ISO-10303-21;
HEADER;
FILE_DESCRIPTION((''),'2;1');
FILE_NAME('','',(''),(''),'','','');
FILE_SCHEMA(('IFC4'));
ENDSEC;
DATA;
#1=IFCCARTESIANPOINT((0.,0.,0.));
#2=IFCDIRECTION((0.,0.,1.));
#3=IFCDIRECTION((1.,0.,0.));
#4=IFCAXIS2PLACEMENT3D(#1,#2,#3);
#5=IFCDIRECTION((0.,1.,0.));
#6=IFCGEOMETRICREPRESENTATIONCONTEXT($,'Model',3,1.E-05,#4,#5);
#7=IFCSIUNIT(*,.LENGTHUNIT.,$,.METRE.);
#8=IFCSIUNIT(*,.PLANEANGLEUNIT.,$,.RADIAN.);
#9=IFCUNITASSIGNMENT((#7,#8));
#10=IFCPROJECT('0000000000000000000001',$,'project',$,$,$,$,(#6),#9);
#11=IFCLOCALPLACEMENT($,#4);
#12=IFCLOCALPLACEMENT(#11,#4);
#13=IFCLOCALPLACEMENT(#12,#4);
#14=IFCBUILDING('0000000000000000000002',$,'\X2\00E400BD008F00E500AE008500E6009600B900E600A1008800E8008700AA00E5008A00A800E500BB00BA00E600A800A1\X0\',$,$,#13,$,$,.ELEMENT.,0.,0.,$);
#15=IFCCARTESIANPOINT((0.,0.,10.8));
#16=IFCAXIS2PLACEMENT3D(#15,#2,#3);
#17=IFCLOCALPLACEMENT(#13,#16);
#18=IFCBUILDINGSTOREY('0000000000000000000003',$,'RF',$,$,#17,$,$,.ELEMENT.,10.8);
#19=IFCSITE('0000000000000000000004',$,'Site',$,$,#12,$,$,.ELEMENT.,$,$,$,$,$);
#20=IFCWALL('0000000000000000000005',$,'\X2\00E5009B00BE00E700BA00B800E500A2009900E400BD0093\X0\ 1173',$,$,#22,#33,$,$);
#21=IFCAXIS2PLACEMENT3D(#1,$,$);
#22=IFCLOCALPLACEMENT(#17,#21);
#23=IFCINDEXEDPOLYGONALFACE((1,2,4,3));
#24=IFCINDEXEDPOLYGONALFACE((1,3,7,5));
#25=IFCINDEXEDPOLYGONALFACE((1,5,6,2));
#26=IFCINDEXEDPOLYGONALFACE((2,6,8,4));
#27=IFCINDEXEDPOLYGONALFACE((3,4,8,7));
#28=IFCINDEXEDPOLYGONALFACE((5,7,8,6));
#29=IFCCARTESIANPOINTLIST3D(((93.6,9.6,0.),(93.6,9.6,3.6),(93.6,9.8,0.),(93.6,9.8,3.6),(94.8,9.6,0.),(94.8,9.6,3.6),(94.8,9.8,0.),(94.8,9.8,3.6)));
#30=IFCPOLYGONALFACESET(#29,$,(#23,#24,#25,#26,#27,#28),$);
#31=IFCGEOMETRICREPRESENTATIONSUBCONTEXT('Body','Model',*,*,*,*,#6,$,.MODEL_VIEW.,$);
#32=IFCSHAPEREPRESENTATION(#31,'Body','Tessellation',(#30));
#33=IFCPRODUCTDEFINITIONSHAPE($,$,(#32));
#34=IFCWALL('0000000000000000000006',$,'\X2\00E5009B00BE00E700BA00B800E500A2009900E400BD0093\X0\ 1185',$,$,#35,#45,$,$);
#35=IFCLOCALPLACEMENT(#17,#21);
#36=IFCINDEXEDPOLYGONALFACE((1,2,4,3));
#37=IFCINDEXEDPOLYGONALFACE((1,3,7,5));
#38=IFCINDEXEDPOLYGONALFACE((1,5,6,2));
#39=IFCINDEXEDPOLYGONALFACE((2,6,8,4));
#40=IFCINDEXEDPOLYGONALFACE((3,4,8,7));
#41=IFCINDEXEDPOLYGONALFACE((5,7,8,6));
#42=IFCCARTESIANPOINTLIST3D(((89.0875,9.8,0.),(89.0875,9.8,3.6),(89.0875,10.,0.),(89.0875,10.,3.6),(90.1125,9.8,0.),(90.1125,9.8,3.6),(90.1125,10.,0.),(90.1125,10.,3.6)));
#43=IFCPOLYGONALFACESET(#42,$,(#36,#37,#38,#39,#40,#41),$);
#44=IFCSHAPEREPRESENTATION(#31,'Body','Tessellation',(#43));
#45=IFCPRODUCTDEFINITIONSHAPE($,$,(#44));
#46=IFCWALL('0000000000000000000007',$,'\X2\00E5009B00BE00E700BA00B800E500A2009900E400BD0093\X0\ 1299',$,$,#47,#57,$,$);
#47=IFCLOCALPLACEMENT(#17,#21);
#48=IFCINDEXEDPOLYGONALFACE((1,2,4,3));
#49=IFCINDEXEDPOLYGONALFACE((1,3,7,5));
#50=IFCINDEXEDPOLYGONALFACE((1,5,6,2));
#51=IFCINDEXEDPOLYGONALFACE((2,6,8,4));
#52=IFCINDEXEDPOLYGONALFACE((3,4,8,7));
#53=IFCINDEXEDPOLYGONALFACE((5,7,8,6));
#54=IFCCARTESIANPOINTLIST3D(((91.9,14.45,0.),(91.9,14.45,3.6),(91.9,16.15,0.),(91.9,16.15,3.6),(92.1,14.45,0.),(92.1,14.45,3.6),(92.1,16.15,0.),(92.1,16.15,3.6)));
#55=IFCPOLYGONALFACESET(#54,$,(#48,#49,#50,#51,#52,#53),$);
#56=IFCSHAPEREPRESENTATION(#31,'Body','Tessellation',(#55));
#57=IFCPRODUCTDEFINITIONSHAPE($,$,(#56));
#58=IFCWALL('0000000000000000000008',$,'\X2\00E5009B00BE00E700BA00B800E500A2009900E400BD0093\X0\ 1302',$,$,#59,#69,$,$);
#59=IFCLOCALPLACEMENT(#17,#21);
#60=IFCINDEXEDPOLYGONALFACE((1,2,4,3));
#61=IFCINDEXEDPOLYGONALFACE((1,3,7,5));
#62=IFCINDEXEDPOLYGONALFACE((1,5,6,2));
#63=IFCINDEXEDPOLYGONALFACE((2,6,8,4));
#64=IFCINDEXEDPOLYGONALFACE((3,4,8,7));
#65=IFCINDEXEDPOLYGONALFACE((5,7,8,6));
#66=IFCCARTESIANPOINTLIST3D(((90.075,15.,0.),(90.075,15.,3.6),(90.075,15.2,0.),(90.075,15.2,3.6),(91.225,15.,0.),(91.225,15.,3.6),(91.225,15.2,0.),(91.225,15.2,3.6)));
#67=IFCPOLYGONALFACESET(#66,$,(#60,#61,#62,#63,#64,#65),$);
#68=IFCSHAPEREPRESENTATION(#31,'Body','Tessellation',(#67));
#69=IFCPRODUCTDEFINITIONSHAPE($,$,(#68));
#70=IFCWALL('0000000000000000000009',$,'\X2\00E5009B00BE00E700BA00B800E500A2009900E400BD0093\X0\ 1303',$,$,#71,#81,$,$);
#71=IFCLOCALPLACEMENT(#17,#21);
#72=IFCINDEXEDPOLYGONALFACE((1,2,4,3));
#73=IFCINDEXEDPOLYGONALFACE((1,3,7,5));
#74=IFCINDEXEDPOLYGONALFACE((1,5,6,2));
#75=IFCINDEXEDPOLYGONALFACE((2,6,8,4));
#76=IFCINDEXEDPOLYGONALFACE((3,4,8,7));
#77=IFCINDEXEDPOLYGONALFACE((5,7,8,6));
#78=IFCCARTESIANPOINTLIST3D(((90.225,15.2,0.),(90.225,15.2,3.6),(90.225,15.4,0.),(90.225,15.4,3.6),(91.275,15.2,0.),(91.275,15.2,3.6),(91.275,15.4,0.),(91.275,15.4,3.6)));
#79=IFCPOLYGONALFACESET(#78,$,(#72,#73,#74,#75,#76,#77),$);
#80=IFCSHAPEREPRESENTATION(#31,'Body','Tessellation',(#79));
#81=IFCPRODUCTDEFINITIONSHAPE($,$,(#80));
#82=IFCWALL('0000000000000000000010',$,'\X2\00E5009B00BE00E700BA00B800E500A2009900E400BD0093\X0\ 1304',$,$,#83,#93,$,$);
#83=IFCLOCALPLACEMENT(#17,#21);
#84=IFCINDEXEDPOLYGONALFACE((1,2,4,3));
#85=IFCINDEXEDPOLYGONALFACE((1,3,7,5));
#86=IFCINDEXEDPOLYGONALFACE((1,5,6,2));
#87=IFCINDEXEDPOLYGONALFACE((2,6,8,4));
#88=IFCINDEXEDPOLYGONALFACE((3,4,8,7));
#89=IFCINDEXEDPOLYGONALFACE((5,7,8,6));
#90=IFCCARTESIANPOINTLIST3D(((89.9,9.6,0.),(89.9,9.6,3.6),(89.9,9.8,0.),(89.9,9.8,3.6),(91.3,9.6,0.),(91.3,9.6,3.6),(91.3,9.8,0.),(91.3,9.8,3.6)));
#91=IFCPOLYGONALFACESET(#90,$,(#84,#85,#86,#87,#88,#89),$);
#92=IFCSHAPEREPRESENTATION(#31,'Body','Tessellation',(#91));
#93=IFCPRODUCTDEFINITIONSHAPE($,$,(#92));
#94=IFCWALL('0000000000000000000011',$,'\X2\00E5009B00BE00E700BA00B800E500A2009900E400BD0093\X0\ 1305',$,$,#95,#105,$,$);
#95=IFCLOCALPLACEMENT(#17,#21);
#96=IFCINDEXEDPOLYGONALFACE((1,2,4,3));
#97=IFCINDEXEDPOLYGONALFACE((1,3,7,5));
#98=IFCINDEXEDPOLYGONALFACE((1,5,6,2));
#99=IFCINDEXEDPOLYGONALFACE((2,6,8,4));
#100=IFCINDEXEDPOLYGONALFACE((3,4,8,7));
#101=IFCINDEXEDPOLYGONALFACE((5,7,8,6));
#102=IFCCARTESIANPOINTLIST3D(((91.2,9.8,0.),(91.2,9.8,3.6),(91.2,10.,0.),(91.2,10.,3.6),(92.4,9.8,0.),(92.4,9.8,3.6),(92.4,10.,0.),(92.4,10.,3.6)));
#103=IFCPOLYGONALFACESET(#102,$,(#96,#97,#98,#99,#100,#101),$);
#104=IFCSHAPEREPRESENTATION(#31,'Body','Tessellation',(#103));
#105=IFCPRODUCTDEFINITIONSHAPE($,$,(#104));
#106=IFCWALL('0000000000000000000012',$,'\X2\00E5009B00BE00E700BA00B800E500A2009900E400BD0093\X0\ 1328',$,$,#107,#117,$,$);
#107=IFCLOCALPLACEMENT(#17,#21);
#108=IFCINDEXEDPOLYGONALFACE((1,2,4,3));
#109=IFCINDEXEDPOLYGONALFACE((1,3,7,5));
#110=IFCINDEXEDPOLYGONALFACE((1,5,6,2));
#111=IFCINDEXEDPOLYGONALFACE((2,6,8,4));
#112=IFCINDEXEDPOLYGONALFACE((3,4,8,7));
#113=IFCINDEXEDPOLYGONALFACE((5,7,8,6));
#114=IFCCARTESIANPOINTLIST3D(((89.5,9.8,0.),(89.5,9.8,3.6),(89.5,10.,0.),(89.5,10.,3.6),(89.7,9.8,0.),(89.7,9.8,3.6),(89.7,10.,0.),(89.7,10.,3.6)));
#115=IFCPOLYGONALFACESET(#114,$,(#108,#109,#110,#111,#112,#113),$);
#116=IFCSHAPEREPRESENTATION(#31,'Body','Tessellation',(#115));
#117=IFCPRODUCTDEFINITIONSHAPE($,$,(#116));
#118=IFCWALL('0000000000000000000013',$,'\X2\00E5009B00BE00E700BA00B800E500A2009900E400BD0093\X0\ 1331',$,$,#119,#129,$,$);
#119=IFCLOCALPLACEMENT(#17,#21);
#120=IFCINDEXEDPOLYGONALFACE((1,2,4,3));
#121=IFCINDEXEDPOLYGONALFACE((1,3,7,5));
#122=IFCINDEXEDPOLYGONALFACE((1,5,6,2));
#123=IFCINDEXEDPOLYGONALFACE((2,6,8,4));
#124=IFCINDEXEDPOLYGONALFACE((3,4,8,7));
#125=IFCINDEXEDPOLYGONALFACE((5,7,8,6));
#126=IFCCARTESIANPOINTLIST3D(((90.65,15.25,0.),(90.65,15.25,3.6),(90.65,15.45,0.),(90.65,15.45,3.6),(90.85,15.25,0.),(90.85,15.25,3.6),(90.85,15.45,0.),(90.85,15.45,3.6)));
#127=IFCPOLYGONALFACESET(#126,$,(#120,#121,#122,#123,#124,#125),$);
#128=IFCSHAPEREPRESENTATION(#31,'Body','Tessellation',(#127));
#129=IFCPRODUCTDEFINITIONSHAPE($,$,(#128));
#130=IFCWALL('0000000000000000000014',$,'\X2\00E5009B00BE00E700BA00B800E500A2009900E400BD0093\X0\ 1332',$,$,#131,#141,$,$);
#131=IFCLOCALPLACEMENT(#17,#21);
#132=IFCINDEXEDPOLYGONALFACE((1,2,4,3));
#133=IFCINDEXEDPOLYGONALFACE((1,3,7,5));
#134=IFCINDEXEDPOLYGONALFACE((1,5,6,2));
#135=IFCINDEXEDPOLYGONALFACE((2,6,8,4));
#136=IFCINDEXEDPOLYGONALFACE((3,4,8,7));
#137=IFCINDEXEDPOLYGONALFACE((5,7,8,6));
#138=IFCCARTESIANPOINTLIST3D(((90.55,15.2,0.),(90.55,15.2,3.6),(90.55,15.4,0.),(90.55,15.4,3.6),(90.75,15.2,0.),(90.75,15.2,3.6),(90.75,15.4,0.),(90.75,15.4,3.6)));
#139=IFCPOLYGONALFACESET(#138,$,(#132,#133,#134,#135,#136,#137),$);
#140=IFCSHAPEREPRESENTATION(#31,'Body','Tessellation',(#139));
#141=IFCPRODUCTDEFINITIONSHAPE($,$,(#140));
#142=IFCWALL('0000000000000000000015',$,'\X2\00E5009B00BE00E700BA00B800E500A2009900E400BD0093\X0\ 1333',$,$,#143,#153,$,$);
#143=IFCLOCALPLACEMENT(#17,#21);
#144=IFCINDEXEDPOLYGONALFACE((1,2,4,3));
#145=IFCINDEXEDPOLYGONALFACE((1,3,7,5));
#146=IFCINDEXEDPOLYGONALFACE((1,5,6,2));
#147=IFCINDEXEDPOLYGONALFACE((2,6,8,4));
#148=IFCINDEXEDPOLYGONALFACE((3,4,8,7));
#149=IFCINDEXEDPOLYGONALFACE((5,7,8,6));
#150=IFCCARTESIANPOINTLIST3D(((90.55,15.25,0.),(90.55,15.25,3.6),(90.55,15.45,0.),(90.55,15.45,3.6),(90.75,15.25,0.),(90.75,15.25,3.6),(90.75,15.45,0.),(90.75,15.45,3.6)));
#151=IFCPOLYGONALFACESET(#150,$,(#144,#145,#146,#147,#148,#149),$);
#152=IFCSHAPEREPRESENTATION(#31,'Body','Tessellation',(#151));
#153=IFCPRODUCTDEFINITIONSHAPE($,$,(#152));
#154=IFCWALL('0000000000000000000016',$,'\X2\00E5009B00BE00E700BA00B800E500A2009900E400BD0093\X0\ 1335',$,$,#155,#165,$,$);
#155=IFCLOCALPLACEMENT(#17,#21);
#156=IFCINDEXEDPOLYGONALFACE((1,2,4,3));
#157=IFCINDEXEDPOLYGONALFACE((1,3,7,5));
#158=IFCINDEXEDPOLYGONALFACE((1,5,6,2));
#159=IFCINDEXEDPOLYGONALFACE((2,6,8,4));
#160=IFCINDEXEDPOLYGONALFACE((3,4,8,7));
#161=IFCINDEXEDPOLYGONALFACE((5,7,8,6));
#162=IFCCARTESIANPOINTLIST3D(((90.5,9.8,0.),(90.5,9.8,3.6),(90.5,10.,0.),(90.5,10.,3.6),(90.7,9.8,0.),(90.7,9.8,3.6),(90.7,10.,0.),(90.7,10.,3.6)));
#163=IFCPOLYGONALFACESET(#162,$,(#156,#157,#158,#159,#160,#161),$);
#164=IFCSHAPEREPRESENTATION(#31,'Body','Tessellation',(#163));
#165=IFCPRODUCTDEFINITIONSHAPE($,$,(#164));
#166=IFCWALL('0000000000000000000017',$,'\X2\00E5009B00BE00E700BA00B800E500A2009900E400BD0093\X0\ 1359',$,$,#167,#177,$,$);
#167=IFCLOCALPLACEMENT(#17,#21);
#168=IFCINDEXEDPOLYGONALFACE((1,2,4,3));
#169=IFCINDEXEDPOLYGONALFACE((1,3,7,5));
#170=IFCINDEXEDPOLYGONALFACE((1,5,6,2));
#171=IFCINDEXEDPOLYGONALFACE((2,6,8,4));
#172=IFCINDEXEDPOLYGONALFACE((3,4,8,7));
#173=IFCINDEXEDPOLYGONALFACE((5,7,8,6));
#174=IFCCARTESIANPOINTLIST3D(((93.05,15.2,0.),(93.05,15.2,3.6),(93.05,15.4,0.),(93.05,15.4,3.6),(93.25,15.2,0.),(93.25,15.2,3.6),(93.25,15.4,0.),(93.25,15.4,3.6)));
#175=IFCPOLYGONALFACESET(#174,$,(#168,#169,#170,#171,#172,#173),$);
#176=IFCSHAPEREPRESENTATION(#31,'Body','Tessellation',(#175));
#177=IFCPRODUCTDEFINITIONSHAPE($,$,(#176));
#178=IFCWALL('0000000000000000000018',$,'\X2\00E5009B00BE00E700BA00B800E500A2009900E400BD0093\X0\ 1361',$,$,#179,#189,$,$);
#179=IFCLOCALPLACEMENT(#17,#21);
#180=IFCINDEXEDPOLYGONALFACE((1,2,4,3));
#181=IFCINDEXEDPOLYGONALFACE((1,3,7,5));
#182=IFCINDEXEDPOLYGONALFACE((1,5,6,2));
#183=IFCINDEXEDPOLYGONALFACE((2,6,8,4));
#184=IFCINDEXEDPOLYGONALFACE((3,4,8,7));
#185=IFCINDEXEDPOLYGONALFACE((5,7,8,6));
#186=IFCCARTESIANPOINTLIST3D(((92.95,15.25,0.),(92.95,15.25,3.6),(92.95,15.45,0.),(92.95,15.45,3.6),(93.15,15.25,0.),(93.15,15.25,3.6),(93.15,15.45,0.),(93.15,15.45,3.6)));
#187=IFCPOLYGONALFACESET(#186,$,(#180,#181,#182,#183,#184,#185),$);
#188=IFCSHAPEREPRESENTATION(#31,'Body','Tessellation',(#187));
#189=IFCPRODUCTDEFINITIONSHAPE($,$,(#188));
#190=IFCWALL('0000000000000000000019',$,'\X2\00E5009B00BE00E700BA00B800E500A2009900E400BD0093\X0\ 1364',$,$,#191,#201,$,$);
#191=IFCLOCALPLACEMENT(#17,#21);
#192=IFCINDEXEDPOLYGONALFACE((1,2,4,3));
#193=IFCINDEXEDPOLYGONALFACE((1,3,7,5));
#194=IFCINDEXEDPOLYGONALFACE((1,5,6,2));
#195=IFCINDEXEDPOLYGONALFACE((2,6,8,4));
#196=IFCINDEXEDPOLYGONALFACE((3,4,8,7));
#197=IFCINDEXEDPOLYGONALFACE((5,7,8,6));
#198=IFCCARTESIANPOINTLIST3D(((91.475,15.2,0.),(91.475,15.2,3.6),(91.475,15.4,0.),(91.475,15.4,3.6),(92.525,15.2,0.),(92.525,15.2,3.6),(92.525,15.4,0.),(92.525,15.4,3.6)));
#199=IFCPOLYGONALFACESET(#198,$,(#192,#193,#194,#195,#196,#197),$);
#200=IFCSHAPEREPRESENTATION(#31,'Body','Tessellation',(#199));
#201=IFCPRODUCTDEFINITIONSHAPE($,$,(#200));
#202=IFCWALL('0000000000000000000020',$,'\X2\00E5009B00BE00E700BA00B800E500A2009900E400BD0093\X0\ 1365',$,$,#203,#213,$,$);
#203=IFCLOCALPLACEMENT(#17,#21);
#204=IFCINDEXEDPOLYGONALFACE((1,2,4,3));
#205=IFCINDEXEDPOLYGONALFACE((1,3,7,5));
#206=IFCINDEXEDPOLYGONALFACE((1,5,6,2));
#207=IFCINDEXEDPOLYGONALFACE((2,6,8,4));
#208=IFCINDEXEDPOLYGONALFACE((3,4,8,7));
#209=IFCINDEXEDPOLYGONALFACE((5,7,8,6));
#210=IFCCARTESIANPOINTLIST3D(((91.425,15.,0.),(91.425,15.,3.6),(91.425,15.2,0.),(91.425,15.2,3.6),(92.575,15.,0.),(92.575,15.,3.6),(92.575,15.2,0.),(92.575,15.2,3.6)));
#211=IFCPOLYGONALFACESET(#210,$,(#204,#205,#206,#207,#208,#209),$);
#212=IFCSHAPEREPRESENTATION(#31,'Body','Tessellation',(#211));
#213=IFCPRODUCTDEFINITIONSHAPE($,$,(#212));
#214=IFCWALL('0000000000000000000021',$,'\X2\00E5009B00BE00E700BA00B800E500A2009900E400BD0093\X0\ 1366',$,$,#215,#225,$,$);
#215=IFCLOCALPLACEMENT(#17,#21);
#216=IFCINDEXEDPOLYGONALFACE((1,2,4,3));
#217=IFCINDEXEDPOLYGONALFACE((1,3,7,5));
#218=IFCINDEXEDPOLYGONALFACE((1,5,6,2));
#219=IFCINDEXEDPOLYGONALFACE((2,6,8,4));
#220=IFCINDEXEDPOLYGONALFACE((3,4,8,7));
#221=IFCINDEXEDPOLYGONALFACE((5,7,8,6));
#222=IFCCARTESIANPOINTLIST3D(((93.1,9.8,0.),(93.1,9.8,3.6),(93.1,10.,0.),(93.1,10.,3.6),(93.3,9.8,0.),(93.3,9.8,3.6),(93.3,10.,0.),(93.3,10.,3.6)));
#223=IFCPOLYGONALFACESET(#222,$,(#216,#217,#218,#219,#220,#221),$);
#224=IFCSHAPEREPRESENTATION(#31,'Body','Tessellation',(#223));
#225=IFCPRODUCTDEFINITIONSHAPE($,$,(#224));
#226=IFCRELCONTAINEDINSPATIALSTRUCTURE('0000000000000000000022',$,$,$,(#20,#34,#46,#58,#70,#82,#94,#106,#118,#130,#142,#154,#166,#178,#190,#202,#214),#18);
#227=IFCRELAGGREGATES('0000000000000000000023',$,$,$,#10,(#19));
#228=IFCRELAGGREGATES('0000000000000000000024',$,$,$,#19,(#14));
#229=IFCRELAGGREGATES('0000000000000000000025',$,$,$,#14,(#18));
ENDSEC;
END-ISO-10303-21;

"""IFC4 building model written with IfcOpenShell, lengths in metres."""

from ifc_helpers import new_model, si_unit, direction, frame, frame_2d, origin_with_axes, place, context, subcontext, project, spatial, rectangle, extrude, element, save


model = new_model("IFC4")

# Units and contexts
model_context = context("Model", 3, precision=1e-05, world=origin_with_axes(), true_north=direction((0.0, 1.0, 0.0)))
body_context = subcontext(model_context, "Body", "Model", "MODEL_VIEW")
ifc_project = project(units=[si_unit("LENGTHUNIT", "METRE"), si_unit("PLANEANGLEUNIT", "RADIAN")], contexts=[model_context])

# Site, building, storey
placement = place(None, origin_with_axes())
site_placement = place(placement, origin_with_axes())
site = spatial("IfcSite", under=ifc_project, at=site_placement, Name="Site", CompositionType="ELEMENT")
building_placement = place(site_placement, origin_with_axes())
building = spatial("IfcBuilding", under=site, at=building_placement, Name="ä½\u008få®\u0085æ\u0096¹æ¡\u0088è\u0087ªå\u008a¨å»ºæ¨¡", CompositionType="ELEMENT", ElevationOfRefHeight=0.0, ElevationOfTerrain=0.0)
storey_placement = place(building_placement, frame((0.0, 0.0, 10.8), z_axis=(0.0, 0.0, 1.0), x_axis=(1.0, 0.0, 0.0)))
storey = spatial("IfcBuildingStorey", under=building, at=storey_placement, Name="RF", CompositionType="ELEMENT", Elevation=10.8)

# Walls
wall_1_placement = place(storey_placement, frame((94.2, 9.7, 0.0), z_axis=(0.0, 0.0, 1.0), x_axis=(1.0, 0.0, 0.0)))
element("IfcWall", 1, at=wall_1_placement, inside=storey, Name="å\u009b¾çº¸å¢\u0099ä½\u0093 1173", context=body_context, shape_type="SweptSolid", body=[
    extrude(rectangle(XDim=1.2, YDim=0.2, at=frame_2d((0.0, 0.0), x_axis=(1.0, 0.0, 0.0))), frame((0.0, 0.0, 0.0), z_axis=(0.0, 0.0, 1.0)), (0.0, 0.0, 1.0), 3.6),
])
wall_2_placement = place(storey_placement, frame((89.6, 9.9, 0.0), z_axis=(0.0, 0.0, 1.0), x_axis=(-1.0, 0.0, 0.0)))
element("IfcWall", 2, at=wall_2_placement, inside=storey, Name="å\u009b¾çº¸å¢\u0099ä½\u0093 1185", context=body_context, shape_type="SweptSolid", body=[
    extrude(rectangle(XDim=1.025, YDim=0.2, at=frame_2d((0.0, 0.0), x_axis=(1.0, 0.0, 0.0))), frame((0.0, 0.0, 0.0), z_axis=(0.0, 0.0, 1.0)), (0.0, 0.0, 1.0), 3.6),
])
wall_3_placement = place(storey_placement, frame((92.0, 15.3, 0.0), z_axis=(0.0, 0.0, 1.0), x_axis=(0.0, 1.0, 0.0)))
element("IfcWall", 3, at=wall_3_placement, inside=storey, Name="å\u009b¾çº¸å¢\u0099ä½\u0093 1299", context=body_context, shape_type="SweptSolid", body=[
    extrude(rectangle(XDim=1.7, YDim=0.2, at=frame_2d((0.0, 0.0), x_axis=(1.0, 0.0, 0.0))), frame((0.0, 0.0, 0.0), z_axis=(0.0, 0.0, 1.0)), (0.0, 0.0, 1.0), 3.6),
])
wall_4_placement = place(storey_placement, frame((90.65, 15.1, 0.0), z_axis=(0.0, 0.0, 1.0), x_axis=(1.0, 0.0, 0.0)))
element("IfcWall", 4, at=wall_4_placement, inside=storey, Name="å\u009b¾çº¸å¢\u0099ä½\u0093 1302", context=body_context, shape_type="SweptSolid", body=[
    extrude(rectangle(XDim=1.15, YDim=0.2, at=frame_2d((0.0, 0.0), x_axis=(1.0, 0.0, 0.0))), frame((0.0, 0.0, 0.0), z_axis=(0.0, 0.0, 1.0)), (0.0, 0.0, 1.0), 3.6),
])
wall_5_placement = place(storey_placement, frame((90.75, 15.3, 0.0), z_axis=(0.0, 0.0, 1.0), x_axis=(1.0, 0.0, 0.0)))
element("IfcWall", 5, at=wall_5_placement, inside=storey, Name="å\u009b¾çº¸å¢\u0099ä½\u0093 1303", context=body_context, shape_type="SweptSolid", body=[
    extrude(rectangle(XDim=1.05, YDim=0.2, at=frame_2d((0.0, 0.0), x_axis=(1.0, 0.0, 0.0))), frame((0.0, 0.0, 0.0), z_axis=(0.0, 0.0, 1.0)), (0.0, 0.0, 1.0), 3.6),
])
wall_6_placement = place(storey_placement, frame((90.6, 9.7, 0.0), z_axis=(0.0, 0.0, 1.0), x_axis=(1.0, 0.0, 0.0)))
element("IfcWall", 6, at=wall_6_placement, inside=storey, Name="å\u009b¾çº¸å¢\u0099ä½\u0093 1304", context=body_context, shape_type="SweptSolid", body=[
    extrude(rectangle(XDim=1.4, YDim=0.2, at=frame_2d((0.0, 0.0), x_axis=(1.0, 0.0, 0.0))), frame((0.0, 0.0, 0.0), z_axis=(0.0, 0.0, 1.0)), (0.0, 0.0, 1.0), 3.6),
])
wall_7_placement = place(storey_placement, frame((91.8, 9.9, 0.0), z_axis=(0.0, 0.0, 1.0), x_axis=(-1.0, 0.0, 0.0)))
element("IfcWall", 7, at=wall_7_placement, inside=storey, Name="å\u009b¾çº¸å¢\u0099ä½\u0093 1305", context=body_context, shape_type="SweptSolid", body=[
    extrude(rectangle(XDim=1.2, YDim=0.2, at=frame_2d((0.0, 0.0), x_axis=(1.0, 0.0, 0.0))), frame((0.0, 0.0, 0.0), z_axis=(0.0, 0.0, 1.0)), (0.0, 0.0, 1.0), 3.6),
])
for number, where, z_axis, x_axis, name in (
    (8, (89.6, 9.9, 0.0), (0.0, 0.0, 1.0), (0.0, -1.0, 0.0), "å\u009b¾çº¸å¢\u0099ä½\u0093 1328"),
    (9, (90.75, 15.35, 0.0), (0.0, 0.0, 1.0), (-1.0, 0.0, 0.0), "å\u009b¾çº¸å¢\u0099ä½\u0093 1331"),
    (10, (90.65, 15.3, 0.0), (0.0, 0.0, 1.0), (0.0, -1.0, 0.0), "å\u009b¾çº¸å¢\u0099ä½\u0093 1332"),
    (11, (90.65, 15.35, 0.0), (0.0, 0.0, 1.0), (0.0, -1.0, 0.0), "å\u009b¾çº¸å¢\u0099ä½\u0093 1333"),
    (12, (90.6, 9.9, 0.0), (0.0, 0.0, 1.0), (0.0, -1.0, 0.0), "å\u009b¾çº¸å¢\u0099ä½\u0093 1335"),
    (13, (93.15, 15.3, 0.0), (0.0, 0.0, 1.0), (0.0, -1.0, 0.0), "å\u009b¾çº¸å¢\u0099ä½\u0093 1359"),
    (14, (93.05, 15.35, 0.0), (0.0, 0.0, 1.0), (1.0, 0.0, 0.0), "å\u009b¾çº¸å¢\u0099ä½\u0093 1361"),
):
    element("IfcWall", number, at=place(storey_placement, frame(where, z_axis=z_axis, x_axis=x_axis)), inside=storey, Name=name, context=body_context, shape_type="SweptSolid", body=[
        extrude(rectangle(XDim=0.2, YDim=0.2, at=frame_2d((0.0, 0.0), x_axis=(1.0, 0.0, 0.0))), frame((0.0, 0.0, 0.0), z_axis=(0.0, 0.0, 1.0)), (0.0, 0.0, 1.0), 3.6),
    ])
wall_8_placement = place(storey_placement, frame((92.0, 15.3, 0.0), z_axis=(0.0, 0.0, 1.0), x_axis=(1.0, 0.0, 0.0)))
element("IfcWall", 15, at=wall_8_placement, inside=storey, Name="å\u009b¾çº¸å¢\u0099ä½\u0093 1364", context=body_context, shape_type="SweptSolid", body=[
    extrude(rectangle(XDim=1.05, YDim=0.2, at=frame_2d((0.0, 0.0), x_axis=(1.0, 0.0, 0.0))), frame((0.0, 0.0, 0.0), z_axis=(0.0, 0.0, 1.0)), (0.0, 0.0, 1.0), 3.6),
])
wall_9_placement = place(storey_placement, frame((92.0, 15.1, 0.0), z_axis=(0.0, 0.0, 1.0), x_axis=(1.0, 0.0, 0.0)))
element("IfcWall", 16, at=wall_9_placement, inside=storey, Name="å\u009b¾çº¸å¢\u0099ä½\u0093 1365", context=body_context, shape_type="SweptSolid", body=[
    extrude(rectangle(XDim=1.15, YDim=0.2, at=frame_2d((0.0, 0.0), x_axis=(1.0, 0.0, 0.0))), frame((0.0, 0.0, 0.0), z_axis=(0.0, 0.0, 1.0)), (0.0, 0.0, 1.0), 3.6),
])
wall_10_placement = place(storey_placement, frame((93.2, 9.9, 0.0), z_axis=(0.0, 0.0, 1.0), x_axis=(0.0, -1.0, 0.0)))
element("IfcWall", 17, at=wall_10_placement, inside=storey, Name="å\u009b¾çº¸å¢\u0099ä½\u0093 1366", context=body_context, shape_type="SweptSolid", body=[
    extrude(rectangle(XDim=0.2, YDim=0.2, at=frame_2d((0.0, 0.0), x_axis=(1.0, 0.0, 0.0))), frame((0.0, 0.0, 0.0), z_axis=(0.0, 0.0, 1.0)), (0.0, 0.0, 1.0), 3.6),
])

save(model, "model.ifc")
